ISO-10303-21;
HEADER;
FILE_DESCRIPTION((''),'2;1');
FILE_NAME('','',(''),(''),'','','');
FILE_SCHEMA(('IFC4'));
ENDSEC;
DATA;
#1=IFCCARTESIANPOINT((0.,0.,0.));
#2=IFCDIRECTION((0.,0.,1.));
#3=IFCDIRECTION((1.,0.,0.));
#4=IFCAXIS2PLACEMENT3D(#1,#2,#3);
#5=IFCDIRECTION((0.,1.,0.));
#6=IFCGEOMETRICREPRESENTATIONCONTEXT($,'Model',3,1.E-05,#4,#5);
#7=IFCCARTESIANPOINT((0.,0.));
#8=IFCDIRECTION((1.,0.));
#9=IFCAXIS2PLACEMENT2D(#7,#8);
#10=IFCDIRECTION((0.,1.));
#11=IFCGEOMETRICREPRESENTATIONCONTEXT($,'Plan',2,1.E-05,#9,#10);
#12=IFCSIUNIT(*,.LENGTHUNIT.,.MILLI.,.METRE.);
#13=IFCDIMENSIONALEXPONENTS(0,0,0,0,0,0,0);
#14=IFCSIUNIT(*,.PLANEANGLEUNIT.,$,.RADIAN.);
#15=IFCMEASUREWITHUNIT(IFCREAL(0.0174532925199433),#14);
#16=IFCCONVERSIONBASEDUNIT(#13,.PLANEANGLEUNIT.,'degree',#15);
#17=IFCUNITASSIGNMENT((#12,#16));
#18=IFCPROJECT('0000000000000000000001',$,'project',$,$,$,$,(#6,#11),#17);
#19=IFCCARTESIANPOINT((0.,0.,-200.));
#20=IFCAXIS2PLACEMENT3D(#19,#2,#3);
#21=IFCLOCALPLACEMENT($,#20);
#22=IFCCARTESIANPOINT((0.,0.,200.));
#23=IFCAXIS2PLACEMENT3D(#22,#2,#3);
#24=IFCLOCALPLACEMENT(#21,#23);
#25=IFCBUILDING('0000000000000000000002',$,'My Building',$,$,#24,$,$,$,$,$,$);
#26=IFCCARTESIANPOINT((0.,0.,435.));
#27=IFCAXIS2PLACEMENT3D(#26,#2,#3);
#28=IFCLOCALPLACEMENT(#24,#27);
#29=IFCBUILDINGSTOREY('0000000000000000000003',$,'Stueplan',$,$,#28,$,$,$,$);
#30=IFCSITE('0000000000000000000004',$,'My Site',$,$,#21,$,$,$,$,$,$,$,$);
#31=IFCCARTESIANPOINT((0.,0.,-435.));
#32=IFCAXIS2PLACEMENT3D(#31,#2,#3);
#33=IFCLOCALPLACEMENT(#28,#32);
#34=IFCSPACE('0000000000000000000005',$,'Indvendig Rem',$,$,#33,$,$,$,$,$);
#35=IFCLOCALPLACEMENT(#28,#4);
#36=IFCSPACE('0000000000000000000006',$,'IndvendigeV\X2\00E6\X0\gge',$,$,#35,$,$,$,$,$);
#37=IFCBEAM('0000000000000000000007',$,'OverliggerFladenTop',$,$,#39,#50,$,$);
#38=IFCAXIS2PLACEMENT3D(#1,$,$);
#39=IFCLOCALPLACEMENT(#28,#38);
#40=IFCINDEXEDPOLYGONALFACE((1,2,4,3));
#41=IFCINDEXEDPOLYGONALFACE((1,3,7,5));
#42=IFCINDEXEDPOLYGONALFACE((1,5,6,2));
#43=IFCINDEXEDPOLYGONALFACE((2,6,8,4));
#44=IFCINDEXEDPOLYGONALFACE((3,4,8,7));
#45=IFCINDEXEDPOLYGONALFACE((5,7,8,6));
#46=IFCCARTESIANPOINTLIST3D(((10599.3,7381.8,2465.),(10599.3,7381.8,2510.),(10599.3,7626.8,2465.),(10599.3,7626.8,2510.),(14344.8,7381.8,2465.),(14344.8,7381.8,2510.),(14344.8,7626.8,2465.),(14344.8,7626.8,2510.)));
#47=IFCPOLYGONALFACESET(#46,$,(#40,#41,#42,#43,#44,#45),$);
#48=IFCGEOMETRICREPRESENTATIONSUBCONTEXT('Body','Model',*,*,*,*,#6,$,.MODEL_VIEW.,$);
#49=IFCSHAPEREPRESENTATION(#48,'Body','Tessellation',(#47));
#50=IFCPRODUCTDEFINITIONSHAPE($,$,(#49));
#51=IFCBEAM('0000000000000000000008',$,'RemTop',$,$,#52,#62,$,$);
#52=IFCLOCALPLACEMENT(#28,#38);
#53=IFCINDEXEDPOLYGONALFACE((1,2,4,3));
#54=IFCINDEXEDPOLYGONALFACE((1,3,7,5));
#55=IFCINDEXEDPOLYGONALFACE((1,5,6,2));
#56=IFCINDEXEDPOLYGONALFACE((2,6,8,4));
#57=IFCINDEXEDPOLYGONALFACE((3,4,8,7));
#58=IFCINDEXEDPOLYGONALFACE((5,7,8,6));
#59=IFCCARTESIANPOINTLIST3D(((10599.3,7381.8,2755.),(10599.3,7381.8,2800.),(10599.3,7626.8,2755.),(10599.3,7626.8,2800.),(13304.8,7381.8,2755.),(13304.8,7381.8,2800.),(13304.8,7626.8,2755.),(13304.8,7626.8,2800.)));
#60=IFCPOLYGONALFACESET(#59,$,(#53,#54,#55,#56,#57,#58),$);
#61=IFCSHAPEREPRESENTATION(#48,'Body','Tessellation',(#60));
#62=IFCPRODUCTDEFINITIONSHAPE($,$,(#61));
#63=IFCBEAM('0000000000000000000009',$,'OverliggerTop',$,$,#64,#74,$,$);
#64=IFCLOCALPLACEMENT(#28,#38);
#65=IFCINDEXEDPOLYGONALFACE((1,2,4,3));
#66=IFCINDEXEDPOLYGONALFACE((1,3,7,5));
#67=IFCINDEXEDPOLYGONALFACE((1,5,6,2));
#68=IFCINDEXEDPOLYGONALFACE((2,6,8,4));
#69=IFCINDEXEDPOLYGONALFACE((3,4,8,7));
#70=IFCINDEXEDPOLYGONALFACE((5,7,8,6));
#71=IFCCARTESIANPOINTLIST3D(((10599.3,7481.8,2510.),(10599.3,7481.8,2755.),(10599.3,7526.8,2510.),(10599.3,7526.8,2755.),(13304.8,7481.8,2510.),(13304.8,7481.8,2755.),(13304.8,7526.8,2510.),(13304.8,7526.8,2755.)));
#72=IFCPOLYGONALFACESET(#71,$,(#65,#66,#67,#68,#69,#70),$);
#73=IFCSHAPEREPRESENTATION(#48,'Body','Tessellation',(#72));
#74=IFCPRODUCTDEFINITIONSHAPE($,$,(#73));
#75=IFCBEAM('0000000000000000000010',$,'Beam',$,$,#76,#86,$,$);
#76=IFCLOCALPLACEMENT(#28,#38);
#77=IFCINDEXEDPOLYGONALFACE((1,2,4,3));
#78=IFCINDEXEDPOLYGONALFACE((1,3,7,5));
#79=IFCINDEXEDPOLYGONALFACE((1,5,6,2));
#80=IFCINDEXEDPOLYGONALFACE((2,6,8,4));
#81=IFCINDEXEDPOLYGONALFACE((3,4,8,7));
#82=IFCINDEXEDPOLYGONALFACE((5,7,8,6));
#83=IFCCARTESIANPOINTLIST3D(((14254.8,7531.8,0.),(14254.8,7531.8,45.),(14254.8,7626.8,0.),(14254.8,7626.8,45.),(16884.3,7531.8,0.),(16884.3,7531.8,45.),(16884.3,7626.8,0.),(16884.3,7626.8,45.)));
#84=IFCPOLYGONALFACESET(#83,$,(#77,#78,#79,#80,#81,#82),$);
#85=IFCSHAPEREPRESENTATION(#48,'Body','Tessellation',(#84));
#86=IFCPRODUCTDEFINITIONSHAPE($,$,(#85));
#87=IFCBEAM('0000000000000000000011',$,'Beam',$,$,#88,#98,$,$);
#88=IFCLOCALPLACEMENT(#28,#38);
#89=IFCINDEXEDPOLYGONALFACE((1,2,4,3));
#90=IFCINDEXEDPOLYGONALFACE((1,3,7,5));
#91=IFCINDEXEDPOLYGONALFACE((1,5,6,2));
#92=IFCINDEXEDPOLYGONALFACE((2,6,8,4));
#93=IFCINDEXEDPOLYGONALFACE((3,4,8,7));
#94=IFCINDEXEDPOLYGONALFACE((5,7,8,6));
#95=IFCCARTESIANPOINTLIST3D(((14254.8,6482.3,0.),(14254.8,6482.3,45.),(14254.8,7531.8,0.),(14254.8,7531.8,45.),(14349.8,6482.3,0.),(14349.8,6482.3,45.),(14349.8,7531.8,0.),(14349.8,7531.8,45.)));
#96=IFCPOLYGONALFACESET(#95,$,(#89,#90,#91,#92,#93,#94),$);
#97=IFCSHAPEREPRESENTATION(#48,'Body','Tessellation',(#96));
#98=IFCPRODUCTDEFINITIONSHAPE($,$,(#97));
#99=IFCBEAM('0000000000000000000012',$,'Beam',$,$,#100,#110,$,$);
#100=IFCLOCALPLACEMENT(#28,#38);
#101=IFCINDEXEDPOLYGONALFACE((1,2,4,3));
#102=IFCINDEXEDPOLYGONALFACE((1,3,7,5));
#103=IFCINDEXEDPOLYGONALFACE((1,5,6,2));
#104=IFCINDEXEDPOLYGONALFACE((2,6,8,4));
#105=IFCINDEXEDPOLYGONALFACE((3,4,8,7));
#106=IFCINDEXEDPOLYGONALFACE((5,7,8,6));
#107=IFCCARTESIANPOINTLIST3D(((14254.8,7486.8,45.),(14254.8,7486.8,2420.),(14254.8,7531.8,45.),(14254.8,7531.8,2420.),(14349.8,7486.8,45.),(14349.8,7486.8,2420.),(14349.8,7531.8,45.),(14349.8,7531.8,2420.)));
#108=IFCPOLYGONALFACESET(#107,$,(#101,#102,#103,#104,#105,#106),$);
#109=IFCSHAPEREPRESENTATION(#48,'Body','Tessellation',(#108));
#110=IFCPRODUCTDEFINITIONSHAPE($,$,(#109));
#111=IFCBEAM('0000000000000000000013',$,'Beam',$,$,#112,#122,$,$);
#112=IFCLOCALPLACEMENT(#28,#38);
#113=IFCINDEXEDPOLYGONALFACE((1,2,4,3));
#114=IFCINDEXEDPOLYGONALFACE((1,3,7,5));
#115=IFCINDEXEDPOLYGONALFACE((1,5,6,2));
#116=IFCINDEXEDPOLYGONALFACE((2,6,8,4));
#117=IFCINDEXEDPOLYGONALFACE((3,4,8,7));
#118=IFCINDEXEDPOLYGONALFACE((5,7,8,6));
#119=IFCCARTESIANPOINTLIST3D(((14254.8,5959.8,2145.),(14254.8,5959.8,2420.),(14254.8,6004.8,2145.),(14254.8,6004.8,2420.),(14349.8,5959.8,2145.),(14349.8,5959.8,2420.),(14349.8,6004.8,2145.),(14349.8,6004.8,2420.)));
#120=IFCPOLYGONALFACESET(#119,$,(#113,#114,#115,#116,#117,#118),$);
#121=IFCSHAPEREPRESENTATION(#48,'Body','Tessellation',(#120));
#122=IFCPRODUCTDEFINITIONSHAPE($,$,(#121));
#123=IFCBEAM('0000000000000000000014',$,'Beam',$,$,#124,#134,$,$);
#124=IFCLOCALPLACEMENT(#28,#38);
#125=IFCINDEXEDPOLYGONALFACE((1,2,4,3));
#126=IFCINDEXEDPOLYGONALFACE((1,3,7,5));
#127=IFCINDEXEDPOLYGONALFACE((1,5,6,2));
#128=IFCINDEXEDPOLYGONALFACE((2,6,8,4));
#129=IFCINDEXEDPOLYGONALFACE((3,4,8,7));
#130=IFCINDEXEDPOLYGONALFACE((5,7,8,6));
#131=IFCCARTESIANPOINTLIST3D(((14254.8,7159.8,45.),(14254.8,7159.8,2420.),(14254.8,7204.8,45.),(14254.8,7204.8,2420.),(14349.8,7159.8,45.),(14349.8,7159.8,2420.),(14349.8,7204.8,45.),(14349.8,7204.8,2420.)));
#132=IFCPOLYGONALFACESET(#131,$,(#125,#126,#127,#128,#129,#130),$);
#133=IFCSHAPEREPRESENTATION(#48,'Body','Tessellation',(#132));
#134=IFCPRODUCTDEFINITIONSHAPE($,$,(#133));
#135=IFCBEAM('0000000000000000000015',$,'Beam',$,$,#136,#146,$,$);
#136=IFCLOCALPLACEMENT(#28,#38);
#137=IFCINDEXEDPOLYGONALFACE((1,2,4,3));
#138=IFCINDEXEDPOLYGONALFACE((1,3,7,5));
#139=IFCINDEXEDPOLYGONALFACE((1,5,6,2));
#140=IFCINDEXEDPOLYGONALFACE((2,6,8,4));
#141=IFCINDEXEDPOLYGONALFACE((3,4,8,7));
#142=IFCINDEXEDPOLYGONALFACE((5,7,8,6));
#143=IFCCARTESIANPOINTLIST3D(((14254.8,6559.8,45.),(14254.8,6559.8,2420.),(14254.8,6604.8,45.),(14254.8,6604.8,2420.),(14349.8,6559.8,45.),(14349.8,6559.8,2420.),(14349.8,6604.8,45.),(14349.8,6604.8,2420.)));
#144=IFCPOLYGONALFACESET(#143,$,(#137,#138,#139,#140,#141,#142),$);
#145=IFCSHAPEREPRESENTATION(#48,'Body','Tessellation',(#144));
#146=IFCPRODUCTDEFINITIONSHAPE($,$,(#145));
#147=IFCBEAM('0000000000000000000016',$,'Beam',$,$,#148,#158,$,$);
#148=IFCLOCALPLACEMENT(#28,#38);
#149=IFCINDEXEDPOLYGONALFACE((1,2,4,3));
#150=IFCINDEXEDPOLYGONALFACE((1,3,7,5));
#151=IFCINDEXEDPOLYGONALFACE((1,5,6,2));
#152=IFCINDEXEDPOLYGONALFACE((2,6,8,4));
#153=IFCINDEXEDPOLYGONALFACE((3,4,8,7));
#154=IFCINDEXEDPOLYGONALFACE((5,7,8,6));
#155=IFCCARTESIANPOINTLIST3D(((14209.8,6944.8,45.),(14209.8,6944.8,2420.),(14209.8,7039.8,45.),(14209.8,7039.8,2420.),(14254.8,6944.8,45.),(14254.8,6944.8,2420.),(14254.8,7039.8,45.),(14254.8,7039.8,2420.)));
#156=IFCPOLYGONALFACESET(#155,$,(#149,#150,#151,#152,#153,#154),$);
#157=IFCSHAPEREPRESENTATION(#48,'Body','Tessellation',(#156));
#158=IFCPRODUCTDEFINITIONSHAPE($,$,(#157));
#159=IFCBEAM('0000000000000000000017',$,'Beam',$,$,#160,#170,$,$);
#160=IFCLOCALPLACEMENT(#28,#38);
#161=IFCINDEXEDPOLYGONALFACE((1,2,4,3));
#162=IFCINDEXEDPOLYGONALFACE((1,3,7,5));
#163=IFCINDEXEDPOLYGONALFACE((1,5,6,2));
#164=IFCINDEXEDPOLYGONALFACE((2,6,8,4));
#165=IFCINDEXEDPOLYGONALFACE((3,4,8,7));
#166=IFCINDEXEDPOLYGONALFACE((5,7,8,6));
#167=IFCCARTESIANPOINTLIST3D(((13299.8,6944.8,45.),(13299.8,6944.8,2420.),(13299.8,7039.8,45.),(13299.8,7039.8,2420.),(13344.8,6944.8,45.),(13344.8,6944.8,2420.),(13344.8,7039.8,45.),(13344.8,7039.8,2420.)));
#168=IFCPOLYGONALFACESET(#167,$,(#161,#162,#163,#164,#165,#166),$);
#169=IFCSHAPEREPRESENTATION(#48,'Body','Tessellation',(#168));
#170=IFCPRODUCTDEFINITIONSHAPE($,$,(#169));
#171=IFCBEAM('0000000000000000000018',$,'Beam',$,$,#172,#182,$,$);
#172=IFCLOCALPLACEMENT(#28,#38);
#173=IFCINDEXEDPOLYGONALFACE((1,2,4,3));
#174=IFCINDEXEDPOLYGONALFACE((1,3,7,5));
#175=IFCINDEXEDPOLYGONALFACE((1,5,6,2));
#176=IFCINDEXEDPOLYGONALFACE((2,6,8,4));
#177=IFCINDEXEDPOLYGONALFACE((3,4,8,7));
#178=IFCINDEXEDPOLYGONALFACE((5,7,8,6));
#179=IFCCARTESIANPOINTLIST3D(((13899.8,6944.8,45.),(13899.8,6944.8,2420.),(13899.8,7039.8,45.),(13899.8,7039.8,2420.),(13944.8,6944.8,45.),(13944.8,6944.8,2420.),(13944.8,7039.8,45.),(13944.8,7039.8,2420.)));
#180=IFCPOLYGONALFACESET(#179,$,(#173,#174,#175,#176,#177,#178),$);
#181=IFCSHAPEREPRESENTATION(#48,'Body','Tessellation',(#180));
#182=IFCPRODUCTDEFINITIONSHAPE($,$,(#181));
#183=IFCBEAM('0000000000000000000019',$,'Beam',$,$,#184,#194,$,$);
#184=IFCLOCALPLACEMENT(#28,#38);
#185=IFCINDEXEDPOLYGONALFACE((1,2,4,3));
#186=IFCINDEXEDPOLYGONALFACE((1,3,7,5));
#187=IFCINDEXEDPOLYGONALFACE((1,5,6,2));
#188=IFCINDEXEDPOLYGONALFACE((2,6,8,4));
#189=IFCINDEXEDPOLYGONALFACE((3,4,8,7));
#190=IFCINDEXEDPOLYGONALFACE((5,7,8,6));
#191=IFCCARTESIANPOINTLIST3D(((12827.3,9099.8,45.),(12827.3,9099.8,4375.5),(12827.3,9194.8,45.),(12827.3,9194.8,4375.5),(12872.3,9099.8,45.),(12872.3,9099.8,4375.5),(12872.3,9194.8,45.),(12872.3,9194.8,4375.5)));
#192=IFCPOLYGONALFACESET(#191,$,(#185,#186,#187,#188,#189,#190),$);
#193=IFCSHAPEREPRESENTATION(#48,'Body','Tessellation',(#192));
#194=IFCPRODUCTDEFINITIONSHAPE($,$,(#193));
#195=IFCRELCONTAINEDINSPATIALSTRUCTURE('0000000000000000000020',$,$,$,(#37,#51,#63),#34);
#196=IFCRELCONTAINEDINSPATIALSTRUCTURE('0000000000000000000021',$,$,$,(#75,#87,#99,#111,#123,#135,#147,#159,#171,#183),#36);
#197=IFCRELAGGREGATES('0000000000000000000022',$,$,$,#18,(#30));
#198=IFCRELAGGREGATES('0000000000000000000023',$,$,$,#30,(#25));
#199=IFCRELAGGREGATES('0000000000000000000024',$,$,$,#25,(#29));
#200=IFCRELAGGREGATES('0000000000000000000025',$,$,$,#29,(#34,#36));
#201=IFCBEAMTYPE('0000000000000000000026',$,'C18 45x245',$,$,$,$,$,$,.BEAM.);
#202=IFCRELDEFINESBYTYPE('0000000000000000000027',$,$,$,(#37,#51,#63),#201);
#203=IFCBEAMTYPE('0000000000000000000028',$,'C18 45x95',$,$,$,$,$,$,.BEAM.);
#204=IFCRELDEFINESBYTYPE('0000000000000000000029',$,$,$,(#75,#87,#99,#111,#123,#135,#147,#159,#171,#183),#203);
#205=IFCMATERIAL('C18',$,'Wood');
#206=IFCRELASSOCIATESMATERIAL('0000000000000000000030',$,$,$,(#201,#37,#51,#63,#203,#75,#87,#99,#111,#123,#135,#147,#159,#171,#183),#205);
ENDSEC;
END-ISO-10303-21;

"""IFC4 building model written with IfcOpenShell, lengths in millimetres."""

from ifc_helpers import new_model, entity, si_unit, converted_unit, direction, frame, origin_with_axes, origin_2d_with_axis, place, context, subcontext, project, spatial, rectangle, extrude, material, material_profile, profile_set, profile_usage, type_object, element, save


model = new_model("IFC4")

# Units and contexts
model_context = context("Model", 3, precision=1e-05, world=origin_with_axes(), true_north=direction((0.0, 1.0, 0.0)))
plan_context = context("Plan", 2, precision=1e-05, world=origin_2d_with_axis(), true_north=direction((0.0, 1.0)))
body_context_1 = subcontext(model_context, "Body", "Model", "MODEL_VIEW")
ifc_project = project(units=[si_unit("LENGTHUNIT", "METRE", prefix="MILLI"), converted_unit("PLANEANGLEUNIT", "degree", entity("IfcReal", 0.0174532925199433), si_unit("PLANEANGLEUNIT", "RADIAN"), dimensions=[0, 0, 0, 0, 0, 0, 0])], contexts=[model_context, plan_context])

# Site, building, storey, space
site_placement = place(None, frame((0.0, 0.0, -200.0), z_axis=(0.0, 0.0, 1.0), x_axis=(1.0, 0.0, 0.0)))
site = spatial("IfcSite", under=ifc_project, at=site_placement, Name="My Site")
building_placement = place(site_placement, frame((0.0, 0.0, 200.0), z_axis=(0.0, 0.0, 1.0), x_axis=(1.0, 0.0, 0.0)))
building = spatial("IfcBuilding", under=site, at=building_placement, Name="My Building")
storey_placement = place(building_placement, frame((0.0, 0.0, 435.0), z_axis=(0.0, 0.0, 1.0), x_axis=(1.0, 0.0, 0.0)))
storey = spatial("IfcBuildingStorey", under=building, at=storey_placement, Name="Stueplan")
space_1_placement = place(storey_placement, frame((0.0, 0.0, -435.0), z_axis=(0.0, 0.0, 1.0), x_axis=(1.0, 0.0, 0.0)))
space_1 = spatial("IfcSpace", under=storey, at=space_1_placement, Name="Indvendig Rem")

# Beams
ifc_material = material(Name="C18", Category="Wood")
ifc_material_profile_1 = material_profile(ifc_material, rectangle(XDim=45.0, YDim=245.0), Name="concrete")
ifc_profile_set_1 = profile_set([ifc_material_profile_1], Name="woodStructural")
ifc_profile_usage_1 = profile_usage(ifc_profile_set_1)
beam_type_1 = type_object("IfcBeamType", Name="C18 45x245", PredefinedType="BEAM", material=ifc_profile_set_1)
beam_1_placement = place(space_1_placement, frame((14344.8, 7504.3, 2922.5), z_axis=(-1.0, 0.0, 0.0), x_axis=(0.0, 0.0, 1.0)))
element("IfcBeam", 1, at=beam_1_placement, inside=space_1, type_object=beam_type_1, material=ifc_profile_usage_1, Name="OverliggerFladenTop", context=body_context_1, shape_type="SweptSolid", body=[
    extrude(rectangle(XDim=45.0, YDim=245.0), origin_with_axes(), (0.0, 0.0, 1.0), 3745.5),
])
ifc_profile_usage_2 = profile_usage(ifc_profile_set_1)
beam_2_placement = place(space_1_placement, frame((13304.8, 7504.3, 3212.5), z_axis=(-1.0, 0.0, 0.0), x_axis=(0.0, 0.0, 1.0)))
element("IfcBeam", 2, at=beam_2_placement, inside=space_1, type_object=beam_type_1, material=ifc_profile_usage_2, Name="RemTop", context=body_context_1, shape_type="SweptSolid", body=[
    extrude(rectangle(XDim=45.0, YDim=245.0), origin_with_axes(), (0.0, 0.0, 1.0), 2705.5),
])
ifc_profile_usage_3 = profile_usage(ifc_profile_set_1)
beam_3_placement = place(space_1_placement, frame((13304.8, 7504.3, 3067.5), z_axis=(-1.0, 0.0, 0.0), x_axis=(0.0, 1.0, 0.0)))
element("IfcBeam", 3, at=beam_3_placement, inside=space_1, type_object=beam_type_1, material=ifc_profile_usage_3, Name="OverliggerTop", context=body_context_1, shape_type="SweptSolid", body=[
    extrude(rectangle(XDim=45.0, YDim=245.0), origin_with_axes(), (0.0, 0.0, 1.0), 2705.5),
])

# Shared definitions
space_2_placement = place(storey_placement, frame((0.0, 0.0, 0.0), z_axis=(0.0, 0.0, 1.0), x_axis=(1.0, 0.0, 0.0)))
space_2 = spatial("IfcSpace", under=storey, at=space_2_placement, Name="IndvendigeVægge")

# Beams
ifc_material_profile_2 = material_profile(ifc_material, rectangle(XDim=45.0, YDim=95.0))
ifc_profile_set_2 = profile_set([ifc_material_profile_2], Name="woodStructural")
ifc_profile_usage_4 = profile_usage(ifc_profile_set_2, cardinal=5)
beam_type_2 = type_object("IfcBeamType", Name="C18 45x95", PredefinedType="BEAM", material=ifc_profile_set_2)
beam_4_placement = place(space_2_placement, frame((14254.8, 7579.3, 22.5), z_axis=(1.0, 0.0, 0.0), x_axis=(0.0, 0.0, 1.0)))
element("IfcBeam", 4, at=beam_4_placement, inside=space_2, type_object=beam_type_2, material=ifc_profile_usage_4, Name="Beam", context=body_context_1, shape_type="SweptSolid", body=[
    extrude(rectangle(XDim=45.0, YDim=95.0), origin_with_axes(), (0.0, 0.0, 1.0), 2629.5),
])
ifc_profile_usage_5 = profile_usage(ifc_profile_set_2, cardinal=5)
beam_5_placement = place(space_2_placement, frame((14302.3, 6482.3, 22.5), z_axis=(0.0, 1.0, 0.0), x_axis=(0.0, 0.0, 1.0)))
element("IfcBeam", 5, at=beam_5_placement, inside=space_2, type_object=beam_type_2, material=ifc_profile_usage_5, Name="Beam", context=body_context_1, shape_type="SweptSolid", body=[
    extrude(rectangle(XDim=45.0, YDim=95.0), origin_with_axes(), (0.0, 0.0, 1.0), 1049.5),
])
ifc_profile_usage_6 = profile_usage(ifc_profile_set_2)
beam_6_placement = place(space_2_placement, frame((14302.3, 7509.3, 45.0), z_axis=(0.0, 0.0, 1.0), x_axis=(0.0, -1.0, 0.0)))
element("IfcBeam", 6, at=beam_6_placement, inside=space_2, type_object=beam_type_2, material=ifc_profile_usage_6, Name="Beam", context=body_context_1, shape_type="SweptSolid", body=[
    extrude(rectangle(XDim=45.0, YDim=95.0), origin_with_axes(), (0.0, 0.0, 1.0), 2375.0),
])
ifc_profile_usage_7 = profile_usage(ifc_profile_set_2)
beam_7_placement = place(space_2_placement, frame((14302.3, 5982.3, 2145.0), z_axis=(0.0, 0.0, 1.0), x_axis=(0.0, -1.0, 0.0)))
element("IfcBeam", 7, at=beam_7_placement, inside=space_2, type_object=beam_type_2, material=ifc_profile_usage_7, Name="Beam", context=body_context_1, shape_type="SweptSolid", body=[
    extrude(rectangle(XDim=45.0, YDim=95.0), origin_with_axes(), (0.0, 0.0, 1.0), 275.0),
])
ifc_profile_usage_8 = profile_usage(ifc_profile_set_2)
beam_8_placement = place(space_2_placement, frame((14302.3, 7182.3, 45.0), z_axis=(0.0, 0.0, 1.0), x_axis=(0.0, -1.0, 0.0)))
element("IfcBeam", 8, at=beam_8_placement, inside=space_2, type_object=beam_type_2, material=ifc_profile_usage_8, Name="Beam", context=body_context_1, shape_type="SweptSolid", body=[
    extrude(rectangle(XDim=45.0, YDim=95.0), origin_with_axes(), (0.0, 0.0, 1.0), 2375.0),
])
ifc_profile_usage_9 = profile_usage(ifc_profile_set_2)
beam_9_placement = place(space_2_placement, frame((14302.3, 6582.3, 45.0), z_axis=(0.0, 0.0, 1.0), x_axis=(0.0, -1.0, 0.0)))
element("IfcBeam", 9, at=beam_9_placement, inside=space_2, type_object=beam_type_2, material=ifc_profile_usage_9, Name="Beam", context=body_context_1, shape_type="SweptSolid", body=[
    extrude(rectangle(XDim=45.0, YDim=95.0), origin_with_axes(), (0.0, 0.0, 1.0), 2375.0),
])
ifc_profile_usage_10 = profile_usage(ifc_profile_set_2)
beam_10_placement = place(space_2_placement, frame((14232.3, 6992.3, 45.0), z_axis=(0.0, 0.0, 1.0), x_axis=(-1.0, 0.0, 0.0)))
element("IfcBeam", 10, at=beam_10_placement, inside=space_2, type_object=beam_type_2, material=ifc_profile_usage_10, Name="Beam", context=body_context_1, shape_type="SweptSolid", body=[
    extrude(rectangle(XDim=45.0, YDim=95.0), origin_with_axes(), (0.0, 0.0, 1.0), 2375.0),
])
ifc_profile_usage_11 = profile_usage(ifc_profile_set_2)
beam_11_placement = place(space_2_placement, frame((13322.3, 6992.3, 45.0), z_axis=(0.0, 0.0, 1.0), x_axis=(-1.0, 0.0, 0.0)))
element("IfcBeam", 11, at=beam_11_placement, inside=space_2, type_object=beam_type_2, material=ifc_profile_usage_11, Name="Beam", context=body_context_1, shape_type="SweptSolid", body=[
    extrude(rectangle(XDim=45.0, YDim=95.0), origin_with_axes(), (0.0, 0.0, 1.0), 2375.0),
])
ifc_profile_usage_12 = profile_usage(ifc_profile_set_2)
beam_12_placement = place(space_2_placement, frame((13922.3, 6992.3, 45.0), z_axis=(0.0, 0.0, 1.0), x_axis=(-1.0, 0.0, 0.0)))
element("IfcBeam", 12, at=beam_12_placement, inside=space_2, type_object=beam_type_2, material=ifc_profile_usage_12, Name="Beam", context=body_context_1, shape_type="SweptSolid", body=[
    extrude(rectangle(XDim=45.0, YDim=95.0), origin_with_axes(), (0.0, 0.0, 1.0), 2375.0),
])
ifc_profile_usage_13 = profile_usage(ifc_profile_set_2)
beam_13_placement = place(space_2_placement, frame((12849.8, 9147.3, 45.0), z_axis=(0.0, 0.0, 1.0), x_axis=(-1.0, 0.0, 0.0)))
element("IfcBeam", 13, at=beam_13_placement, inside=space_2, type_object=beam_type_2, material=ifc_profile_usage_13, Name="Beam", context=body_context_1, shape_type="SweptSolid", body=[
    extrude(rectangle(XDim=45.0, YDim=95.0), origin_with_axes(), (0.0, 0.0, 1.0), 4330.5),
])

save(model, "model.ifc")
